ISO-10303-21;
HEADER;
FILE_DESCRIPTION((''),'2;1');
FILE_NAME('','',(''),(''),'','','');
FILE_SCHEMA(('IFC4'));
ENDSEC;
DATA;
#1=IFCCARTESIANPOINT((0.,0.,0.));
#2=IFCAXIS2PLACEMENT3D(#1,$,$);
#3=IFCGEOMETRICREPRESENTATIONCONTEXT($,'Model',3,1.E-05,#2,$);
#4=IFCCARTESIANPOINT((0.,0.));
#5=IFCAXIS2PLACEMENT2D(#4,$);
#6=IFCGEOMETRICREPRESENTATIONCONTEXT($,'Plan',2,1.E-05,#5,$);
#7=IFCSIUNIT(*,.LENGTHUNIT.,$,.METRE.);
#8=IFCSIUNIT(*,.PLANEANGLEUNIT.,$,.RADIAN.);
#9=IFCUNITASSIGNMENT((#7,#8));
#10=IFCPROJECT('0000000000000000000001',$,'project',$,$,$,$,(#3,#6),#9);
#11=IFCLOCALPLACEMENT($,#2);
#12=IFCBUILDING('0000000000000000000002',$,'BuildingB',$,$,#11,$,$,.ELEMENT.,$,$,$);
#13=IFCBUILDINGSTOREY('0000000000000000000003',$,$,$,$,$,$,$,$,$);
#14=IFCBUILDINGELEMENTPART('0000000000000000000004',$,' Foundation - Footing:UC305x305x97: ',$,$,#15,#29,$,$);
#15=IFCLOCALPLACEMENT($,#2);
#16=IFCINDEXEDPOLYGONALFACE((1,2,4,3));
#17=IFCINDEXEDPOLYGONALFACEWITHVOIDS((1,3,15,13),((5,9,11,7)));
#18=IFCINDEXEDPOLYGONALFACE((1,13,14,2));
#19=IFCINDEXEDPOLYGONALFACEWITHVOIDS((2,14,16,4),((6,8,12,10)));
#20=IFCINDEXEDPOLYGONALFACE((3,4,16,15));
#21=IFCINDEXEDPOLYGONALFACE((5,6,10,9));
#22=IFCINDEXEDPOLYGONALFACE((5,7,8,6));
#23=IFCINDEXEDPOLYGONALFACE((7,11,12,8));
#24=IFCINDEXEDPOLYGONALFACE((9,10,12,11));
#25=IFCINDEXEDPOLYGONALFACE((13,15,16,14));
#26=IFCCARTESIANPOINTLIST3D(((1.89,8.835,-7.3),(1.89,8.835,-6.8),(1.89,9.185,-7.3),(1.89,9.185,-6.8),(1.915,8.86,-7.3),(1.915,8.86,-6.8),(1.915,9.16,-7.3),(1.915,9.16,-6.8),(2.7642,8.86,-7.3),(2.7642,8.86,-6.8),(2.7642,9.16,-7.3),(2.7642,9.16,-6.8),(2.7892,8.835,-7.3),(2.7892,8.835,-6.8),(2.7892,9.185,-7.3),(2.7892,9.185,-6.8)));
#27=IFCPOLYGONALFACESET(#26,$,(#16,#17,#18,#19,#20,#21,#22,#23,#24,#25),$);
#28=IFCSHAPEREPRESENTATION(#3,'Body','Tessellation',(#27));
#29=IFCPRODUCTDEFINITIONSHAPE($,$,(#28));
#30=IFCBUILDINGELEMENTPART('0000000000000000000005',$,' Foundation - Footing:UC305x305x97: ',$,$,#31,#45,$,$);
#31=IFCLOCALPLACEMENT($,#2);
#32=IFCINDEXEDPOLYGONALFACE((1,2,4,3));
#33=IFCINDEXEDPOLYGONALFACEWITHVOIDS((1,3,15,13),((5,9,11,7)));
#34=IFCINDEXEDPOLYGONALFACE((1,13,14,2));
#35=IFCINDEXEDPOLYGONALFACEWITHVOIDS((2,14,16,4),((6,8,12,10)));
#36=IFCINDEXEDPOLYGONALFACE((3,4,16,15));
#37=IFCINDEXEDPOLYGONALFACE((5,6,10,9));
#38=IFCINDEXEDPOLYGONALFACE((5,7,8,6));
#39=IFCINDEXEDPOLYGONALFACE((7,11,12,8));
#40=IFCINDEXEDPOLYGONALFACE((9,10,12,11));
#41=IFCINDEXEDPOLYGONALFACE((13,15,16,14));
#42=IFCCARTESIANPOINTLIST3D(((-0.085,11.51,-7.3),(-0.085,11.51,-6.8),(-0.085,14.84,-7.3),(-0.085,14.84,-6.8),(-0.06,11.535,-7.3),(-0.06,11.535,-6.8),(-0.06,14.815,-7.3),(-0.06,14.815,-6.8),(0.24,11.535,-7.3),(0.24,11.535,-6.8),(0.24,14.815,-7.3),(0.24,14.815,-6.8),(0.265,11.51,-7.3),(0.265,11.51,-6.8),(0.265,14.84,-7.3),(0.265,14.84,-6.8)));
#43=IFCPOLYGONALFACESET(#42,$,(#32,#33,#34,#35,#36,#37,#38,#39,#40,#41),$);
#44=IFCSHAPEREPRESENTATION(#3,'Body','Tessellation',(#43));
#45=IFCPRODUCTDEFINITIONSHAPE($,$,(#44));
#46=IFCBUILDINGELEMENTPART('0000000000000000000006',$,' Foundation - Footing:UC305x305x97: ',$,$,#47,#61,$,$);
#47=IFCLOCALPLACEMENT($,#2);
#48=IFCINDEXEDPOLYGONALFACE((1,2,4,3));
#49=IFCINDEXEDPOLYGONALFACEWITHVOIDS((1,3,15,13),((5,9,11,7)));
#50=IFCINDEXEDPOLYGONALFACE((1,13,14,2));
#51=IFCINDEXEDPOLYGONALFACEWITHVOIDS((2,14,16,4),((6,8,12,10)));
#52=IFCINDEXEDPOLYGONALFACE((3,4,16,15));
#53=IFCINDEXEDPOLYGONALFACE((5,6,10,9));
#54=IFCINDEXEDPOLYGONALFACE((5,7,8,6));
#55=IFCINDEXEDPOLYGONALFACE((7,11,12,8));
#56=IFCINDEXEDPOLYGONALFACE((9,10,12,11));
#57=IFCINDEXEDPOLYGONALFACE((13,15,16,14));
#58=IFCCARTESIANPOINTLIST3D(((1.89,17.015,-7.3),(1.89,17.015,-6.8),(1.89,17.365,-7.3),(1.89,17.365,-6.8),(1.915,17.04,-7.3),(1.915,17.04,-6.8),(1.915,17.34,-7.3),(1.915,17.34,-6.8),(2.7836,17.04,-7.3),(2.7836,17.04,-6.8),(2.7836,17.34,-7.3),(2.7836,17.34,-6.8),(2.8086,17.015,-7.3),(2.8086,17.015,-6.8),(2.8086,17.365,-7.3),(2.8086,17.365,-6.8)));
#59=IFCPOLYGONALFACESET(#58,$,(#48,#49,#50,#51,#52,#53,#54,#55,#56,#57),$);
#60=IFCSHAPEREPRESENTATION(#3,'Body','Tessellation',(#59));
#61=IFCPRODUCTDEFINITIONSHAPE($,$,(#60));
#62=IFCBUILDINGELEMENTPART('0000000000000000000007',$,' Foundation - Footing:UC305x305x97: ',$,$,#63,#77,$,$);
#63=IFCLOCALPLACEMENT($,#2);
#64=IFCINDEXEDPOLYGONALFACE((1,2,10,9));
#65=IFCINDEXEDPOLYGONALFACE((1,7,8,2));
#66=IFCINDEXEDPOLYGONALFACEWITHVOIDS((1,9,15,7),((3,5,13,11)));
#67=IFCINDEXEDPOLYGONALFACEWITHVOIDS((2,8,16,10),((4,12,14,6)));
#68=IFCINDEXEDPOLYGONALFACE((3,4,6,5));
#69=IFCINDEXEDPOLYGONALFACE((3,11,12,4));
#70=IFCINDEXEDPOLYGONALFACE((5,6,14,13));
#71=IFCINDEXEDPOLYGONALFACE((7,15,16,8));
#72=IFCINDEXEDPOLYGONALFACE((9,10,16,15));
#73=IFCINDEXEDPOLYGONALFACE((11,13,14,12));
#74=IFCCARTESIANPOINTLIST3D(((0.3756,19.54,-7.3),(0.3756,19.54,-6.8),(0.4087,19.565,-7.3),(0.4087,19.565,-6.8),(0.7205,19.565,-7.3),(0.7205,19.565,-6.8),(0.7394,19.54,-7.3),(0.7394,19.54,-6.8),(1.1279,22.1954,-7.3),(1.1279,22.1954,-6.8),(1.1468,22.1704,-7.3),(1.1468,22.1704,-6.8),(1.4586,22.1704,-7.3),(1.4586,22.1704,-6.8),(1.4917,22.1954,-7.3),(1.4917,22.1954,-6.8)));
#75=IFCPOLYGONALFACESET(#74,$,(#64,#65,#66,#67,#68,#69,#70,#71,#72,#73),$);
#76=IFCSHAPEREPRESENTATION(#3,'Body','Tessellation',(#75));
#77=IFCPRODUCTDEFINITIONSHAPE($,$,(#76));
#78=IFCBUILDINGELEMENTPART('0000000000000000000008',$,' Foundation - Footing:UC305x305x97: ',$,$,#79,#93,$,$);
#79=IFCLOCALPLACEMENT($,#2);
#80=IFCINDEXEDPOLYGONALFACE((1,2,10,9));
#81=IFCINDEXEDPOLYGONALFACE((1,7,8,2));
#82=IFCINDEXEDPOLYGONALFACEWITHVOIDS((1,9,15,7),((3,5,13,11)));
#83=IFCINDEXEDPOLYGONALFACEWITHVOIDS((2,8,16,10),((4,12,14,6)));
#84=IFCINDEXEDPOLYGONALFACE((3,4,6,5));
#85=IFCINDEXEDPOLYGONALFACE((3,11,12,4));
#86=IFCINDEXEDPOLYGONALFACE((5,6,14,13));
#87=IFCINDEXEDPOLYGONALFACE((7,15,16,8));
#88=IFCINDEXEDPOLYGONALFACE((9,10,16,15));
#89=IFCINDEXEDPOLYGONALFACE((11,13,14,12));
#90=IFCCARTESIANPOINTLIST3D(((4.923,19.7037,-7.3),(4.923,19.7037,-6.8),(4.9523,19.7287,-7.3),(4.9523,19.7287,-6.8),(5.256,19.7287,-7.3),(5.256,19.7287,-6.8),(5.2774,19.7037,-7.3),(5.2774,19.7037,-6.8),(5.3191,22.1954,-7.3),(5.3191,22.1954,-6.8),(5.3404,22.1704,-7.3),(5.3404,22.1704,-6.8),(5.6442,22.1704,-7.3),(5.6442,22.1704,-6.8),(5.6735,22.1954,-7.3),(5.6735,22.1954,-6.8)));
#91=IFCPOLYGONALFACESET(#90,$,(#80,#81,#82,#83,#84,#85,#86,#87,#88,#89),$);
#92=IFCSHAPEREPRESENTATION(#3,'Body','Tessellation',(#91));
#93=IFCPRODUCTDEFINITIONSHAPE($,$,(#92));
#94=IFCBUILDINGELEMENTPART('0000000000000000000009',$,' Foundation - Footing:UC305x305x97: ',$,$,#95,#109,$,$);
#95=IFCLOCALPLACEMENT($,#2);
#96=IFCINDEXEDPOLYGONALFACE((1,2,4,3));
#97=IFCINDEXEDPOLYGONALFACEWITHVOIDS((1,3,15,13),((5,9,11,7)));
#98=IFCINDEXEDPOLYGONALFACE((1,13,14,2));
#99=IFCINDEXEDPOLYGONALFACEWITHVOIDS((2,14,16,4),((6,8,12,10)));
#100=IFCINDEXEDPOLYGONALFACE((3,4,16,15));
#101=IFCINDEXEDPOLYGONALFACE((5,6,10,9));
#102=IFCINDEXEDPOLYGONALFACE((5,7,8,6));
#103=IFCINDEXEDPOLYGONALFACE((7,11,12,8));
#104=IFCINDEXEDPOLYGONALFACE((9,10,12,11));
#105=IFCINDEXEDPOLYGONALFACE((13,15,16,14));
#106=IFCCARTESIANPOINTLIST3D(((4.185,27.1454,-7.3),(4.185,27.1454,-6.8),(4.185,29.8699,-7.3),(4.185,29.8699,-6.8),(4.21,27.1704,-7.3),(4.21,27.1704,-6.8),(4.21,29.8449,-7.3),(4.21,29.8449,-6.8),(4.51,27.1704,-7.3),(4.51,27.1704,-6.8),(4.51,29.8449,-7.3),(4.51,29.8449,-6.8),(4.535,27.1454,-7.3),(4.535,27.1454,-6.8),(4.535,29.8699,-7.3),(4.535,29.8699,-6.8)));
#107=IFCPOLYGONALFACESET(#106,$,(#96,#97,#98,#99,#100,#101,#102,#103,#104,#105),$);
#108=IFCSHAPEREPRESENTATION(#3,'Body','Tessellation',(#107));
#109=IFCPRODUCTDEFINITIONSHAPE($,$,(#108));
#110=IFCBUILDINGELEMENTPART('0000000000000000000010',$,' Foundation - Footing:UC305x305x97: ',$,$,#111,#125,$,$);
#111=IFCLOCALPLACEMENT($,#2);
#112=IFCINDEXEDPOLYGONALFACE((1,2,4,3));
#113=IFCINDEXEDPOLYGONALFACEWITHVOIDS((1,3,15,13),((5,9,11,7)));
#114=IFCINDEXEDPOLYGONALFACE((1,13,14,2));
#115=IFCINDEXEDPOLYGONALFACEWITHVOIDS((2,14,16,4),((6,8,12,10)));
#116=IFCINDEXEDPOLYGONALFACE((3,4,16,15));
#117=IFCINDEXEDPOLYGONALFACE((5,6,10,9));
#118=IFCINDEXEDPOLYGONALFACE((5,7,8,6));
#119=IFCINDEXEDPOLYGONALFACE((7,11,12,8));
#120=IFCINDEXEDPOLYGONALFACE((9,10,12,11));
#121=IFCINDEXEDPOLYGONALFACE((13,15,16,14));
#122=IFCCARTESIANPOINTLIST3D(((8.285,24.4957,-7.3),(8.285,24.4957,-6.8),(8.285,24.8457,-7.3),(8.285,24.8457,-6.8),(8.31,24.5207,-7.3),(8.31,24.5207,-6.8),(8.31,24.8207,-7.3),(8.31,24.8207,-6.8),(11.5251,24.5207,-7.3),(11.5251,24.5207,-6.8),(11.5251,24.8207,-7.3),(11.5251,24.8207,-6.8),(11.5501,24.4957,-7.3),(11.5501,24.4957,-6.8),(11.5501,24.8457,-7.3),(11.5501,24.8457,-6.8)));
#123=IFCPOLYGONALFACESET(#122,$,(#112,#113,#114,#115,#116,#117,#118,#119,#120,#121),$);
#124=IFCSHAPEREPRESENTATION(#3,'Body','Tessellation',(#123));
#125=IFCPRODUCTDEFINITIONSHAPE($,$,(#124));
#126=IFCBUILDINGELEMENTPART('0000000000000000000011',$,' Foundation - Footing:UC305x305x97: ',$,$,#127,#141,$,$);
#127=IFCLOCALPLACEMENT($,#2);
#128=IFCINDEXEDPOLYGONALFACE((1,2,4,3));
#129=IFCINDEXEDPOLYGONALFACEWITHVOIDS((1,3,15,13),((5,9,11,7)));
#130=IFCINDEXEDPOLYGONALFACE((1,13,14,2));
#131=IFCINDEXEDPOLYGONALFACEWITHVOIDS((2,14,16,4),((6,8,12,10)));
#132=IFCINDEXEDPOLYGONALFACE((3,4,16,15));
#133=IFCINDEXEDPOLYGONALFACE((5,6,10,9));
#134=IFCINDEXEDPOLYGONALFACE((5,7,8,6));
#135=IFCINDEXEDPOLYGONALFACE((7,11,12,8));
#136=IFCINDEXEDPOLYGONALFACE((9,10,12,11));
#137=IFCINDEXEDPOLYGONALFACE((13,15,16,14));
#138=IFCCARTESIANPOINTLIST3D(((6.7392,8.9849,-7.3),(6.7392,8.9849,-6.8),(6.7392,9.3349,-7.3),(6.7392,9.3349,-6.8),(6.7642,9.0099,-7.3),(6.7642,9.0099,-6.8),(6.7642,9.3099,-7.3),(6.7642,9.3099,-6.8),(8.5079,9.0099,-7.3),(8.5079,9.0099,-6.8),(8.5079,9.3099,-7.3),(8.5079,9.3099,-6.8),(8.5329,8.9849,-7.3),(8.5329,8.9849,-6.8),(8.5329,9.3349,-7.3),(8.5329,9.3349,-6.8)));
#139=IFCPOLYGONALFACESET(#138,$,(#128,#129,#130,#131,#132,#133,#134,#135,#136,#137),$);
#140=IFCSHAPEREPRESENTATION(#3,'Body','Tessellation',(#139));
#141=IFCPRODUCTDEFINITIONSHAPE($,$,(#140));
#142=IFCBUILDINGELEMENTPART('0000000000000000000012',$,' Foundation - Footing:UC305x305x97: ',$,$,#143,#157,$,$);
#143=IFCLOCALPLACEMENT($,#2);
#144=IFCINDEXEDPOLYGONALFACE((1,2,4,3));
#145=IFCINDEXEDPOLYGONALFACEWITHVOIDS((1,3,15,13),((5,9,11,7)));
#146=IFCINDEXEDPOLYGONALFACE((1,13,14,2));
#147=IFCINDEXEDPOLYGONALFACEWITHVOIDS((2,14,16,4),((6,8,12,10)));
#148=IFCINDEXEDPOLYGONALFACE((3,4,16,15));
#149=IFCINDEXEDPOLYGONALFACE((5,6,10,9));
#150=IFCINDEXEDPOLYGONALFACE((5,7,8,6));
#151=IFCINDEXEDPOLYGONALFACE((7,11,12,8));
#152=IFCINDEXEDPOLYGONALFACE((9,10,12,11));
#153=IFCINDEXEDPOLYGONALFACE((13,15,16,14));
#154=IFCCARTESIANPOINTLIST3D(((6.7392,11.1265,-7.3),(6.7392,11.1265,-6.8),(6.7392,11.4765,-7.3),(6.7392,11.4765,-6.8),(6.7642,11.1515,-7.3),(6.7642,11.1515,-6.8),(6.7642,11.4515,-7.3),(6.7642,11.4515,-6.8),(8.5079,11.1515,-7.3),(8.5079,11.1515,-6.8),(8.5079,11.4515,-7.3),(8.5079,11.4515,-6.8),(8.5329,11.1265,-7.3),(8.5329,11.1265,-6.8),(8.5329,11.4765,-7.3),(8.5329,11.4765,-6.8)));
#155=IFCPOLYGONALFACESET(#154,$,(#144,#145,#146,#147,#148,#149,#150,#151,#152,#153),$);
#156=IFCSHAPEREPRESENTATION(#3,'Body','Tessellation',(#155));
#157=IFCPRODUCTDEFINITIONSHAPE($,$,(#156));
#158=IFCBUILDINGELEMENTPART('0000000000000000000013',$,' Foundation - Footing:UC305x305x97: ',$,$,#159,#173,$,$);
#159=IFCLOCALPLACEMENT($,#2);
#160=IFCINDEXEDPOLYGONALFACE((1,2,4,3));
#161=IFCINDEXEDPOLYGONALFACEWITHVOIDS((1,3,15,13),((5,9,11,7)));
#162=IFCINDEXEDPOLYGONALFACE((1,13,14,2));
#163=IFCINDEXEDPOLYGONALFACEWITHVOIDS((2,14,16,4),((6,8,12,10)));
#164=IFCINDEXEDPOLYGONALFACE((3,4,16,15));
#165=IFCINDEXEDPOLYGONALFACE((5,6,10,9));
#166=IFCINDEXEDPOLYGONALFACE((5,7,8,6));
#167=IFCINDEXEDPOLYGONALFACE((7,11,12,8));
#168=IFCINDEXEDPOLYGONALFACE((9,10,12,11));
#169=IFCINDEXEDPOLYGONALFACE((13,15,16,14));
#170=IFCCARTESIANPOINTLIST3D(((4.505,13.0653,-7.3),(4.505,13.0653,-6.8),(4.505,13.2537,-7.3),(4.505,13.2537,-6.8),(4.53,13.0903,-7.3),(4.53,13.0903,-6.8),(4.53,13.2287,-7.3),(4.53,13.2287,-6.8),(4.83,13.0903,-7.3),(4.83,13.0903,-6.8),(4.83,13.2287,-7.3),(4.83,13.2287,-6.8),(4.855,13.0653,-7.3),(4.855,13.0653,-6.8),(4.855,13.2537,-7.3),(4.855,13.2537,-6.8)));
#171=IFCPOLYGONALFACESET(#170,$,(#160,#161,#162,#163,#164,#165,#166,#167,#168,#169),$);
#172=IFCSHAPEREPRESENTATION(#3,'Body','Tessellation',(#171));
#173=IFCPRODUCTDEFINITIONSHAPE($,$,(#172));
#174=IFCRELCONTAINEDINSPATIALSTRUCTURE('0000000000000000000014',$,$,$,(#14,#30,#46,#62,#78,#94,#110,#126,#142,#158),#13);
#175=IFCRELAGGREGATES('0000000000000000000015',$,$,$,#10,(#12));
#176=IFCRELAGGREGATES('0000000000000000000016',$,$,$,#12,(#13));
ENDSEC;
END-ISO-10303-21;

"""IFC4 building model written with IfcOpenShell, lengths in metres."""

from ifc_helpers import new_model, si_unit, origin, origin_2d, place, context, project, spatial, polyline, outline, extrude, element, save


model = new_model("IFC4")

# Units and contexts
model_context = context("Model", 3, precision=1e-05, world=origin())
plan_context = context("Plan", 2, precision=1e-05, world=origin_2d())
ifc_project = project(units=[si_unit("LENGTHUNIT", "METRE"), si_unit("PLANEANGLEUNIT", "RADIAN")], contexts=[model_context, plan_context])

# Building, storey
building_placement = place(None, origin())
building = spatial("IfcBuilding", under=ifc_project, at=building_placement, Name="BuildingB", CompositionType="ELEMENT")
storey = spatial("IfcBuildingStorey", under=building)

# Building element parts, openings
building_element_part_1 = element("IfcBuildingElementPart", 1, inside=storey, Name=" Foundation - Footing:UC305x305x97: ", context=model_context, shape_type="SweptSolid", body=[
    extrude(outline(polyline([(1.89, 8.835, -7.3), (1.89, 9.185, -7.3), (2.7892, 9.185, -7.3), (2.7892, 8.835, -7.3), (1.89, 8.835, -7.3)])), None, (0.0, 0.0, 1.0), 0.5),
])
element("IfcOpeningElement", 2, inside=storey, cuts=building_element_part_1, context=model_context, shape_type="SweptSolid", body=[
    extrude(outline(polyline([(1.915, 8.86, -7.3), (1.915, 9.16, -7.3), (2.7642, 9.16, -7.3), (2.7642, 8.86, -7.3), (1.915, 8.86, -7.3)])), None, (0.0, 0.0, 1.0), 0.5),
])
building_element_part_2 = element("IfcBuildingElementPart", 3, inside=storey, Name=" Foundation - Footing:UC305x305x97: ", context=model_context, shape_type="SweptSolid", body=[
    extrude(outline(polyline([(-0.085, 11.51, -7.3), (-0.085, 14.84, -7.3), (0.265, 14.84, -7.3), (0.265, 11.51, -7.3), (-0.085, 11.51, -7.3)])), None, (0.0, 0.0, 1.0), 0.5),
])
element("IfcOpeningElement", 4, inside=storey, cuts=building_element_part_2, context=model_context, shape_type="SweptSolid", body=[
    extrude(outline(polyline([(-0.06, 11.535, -7.3), (-0.06, 14.815, -7.3), (0.24, 14.815, -7.3), (0.24, 11.535, -7.3), (-0.06, 11.535, -7.3)])), None, (0.0, 0.0, 1.0), 0.5),
])
building_element_part_3 = element("IfcBuildingElementPart", 5, inside=storey, Name=" Foundation - Footing:UC305x305x97: ", context=model_context, shape_type="SweptSolid", body=[
    extrude(outline(polyline([(1.89, 17.015, -7.3), (1.89, 17.365, -7.3), (2.8086, 17.365, -7.3), (2.8086, 17.015, -7.3), (1.89, 17.015, -7.3)])), None, (0.0, 0.0, 1.0), 0.5),
])
element("IfcOpeningElement", 6, inside=storey, cuts=building_element_part_3, context=model_context, shape_type="SweptSolid", body=[
    extrude(outline(polyline([(1.915, 17.04, -7.3), (1.915, 17.34, -7.3), (2.7836, 17.34, -7.3), (2.7836, 17.04, -7.3), (1.915, 17.04, -7.3)])), None, (0.0, 0.0, 1.0), 0.5),
])
building_element_part_4 = element("IfcBuildingElementPart", 7, inside=storey, Name=" Foundation - Footing:UC305x305x97: ", context=model_context, shape_type="SweptSolid", body=[
    extrude(outline(polyline([(0.3756, 19.54, -7.3), (1.1279, 22.1954, -7.3), (1.4917, 22.1954, -7.3), (0.7394, 19.54, -7.3), (0.3756, 19.54, -7.3)])), None, (0.0, 0.0, 1.0), 0.5),
])
element("IfcOpeningElement", 8, inside=storey, cuts=building_element_part_4, context=model_context, shape_type="SweptSolid", body=[
    extrude(outline(polyline([(0.4087, 19.565, -7.3), (1.1468, 22.1704, -7.3), (1.4586, 22.1704, -7.3), (0.7205, 19.565, -7.3), (0.4087, 19.565, -7.3)])), None, (0.0, 0.0, 1.0), 0.5),
])
building_element_part_5 = element("IfcBuildingElementPart", 9, inside=storey, Name=" Foundation - Footing:UC305x305x97: ", context=model_context, shape_type="SweptSolid", body=[
    extrude(outline(polyline([(5.2774, 19.7037, -7.3), (4.923, 19.7037, -7.3), (5.3191, 22.1954, -7.3), (5.6735, 22.1954, -7.3), (5.2774, 19.7037, -7.3)])), None, (0.0, 0.0, 1.0), 0.5),
])
element("IfcOpeningElement", 10, inside=storey, cuts=building_element_part_5, context=model_context, shape_type="SweptSolid", body=[
    extrude(outline(polyline([(5.256, 19.7287, -7.3), (4.9523, 19.7287, -7.3), (5.3404, 22.1704, -7.3), (5.6442, 22.1704, -7.3), (5.256, 19.7287, -7.3)])), None, (0.0, 0.0, 1.0), 0.5),
])
building_element_part_6 = element("IfcBuildingElementPart", 11, inside=storey, Name=" Foundation - Footing:UC305x305x97: ", context=model_context, shape_type="SweptSolid", body=[
    extrude(outline(polyline([(4.535, 27.1454, -7.3), (4.185, 27.1454, -7.3), (4.185, 29.8699, -7.3), (4.535, 29.8699, -7.3), (4.535, 27.1454, -7.3)])), None, (0.0, 0.0, 1.0), 0.5),
])
element("IfcOpeningElement", 12, inside=storey, cuts=building_element_part_6, context=model_context, shape_type="SweptSolid", body=[
    extrude(outline(polyline([(4.51, 27.1704, -7.3), (4.21, 27.1704, -7.3), (4.21, 29.8449, -7.3), (4.51, 29.8449, -7.3), (4.51, 27.1704, -7.3)])), None, (0.0, 0.0, 1.0), 0.5),
])
building_element_part_7 = element("IfcBuildingElementPart", 13, inside=storey, Name=" Foundation - Footing:UC305x305x97: ", context=model_context, shape_type="SweptSolid", body=[
    extrude(outline(polyline([(8.285, 24.4957, -7.3), (8.285, 24.8457, -7.3), (11.5501, 24.8457, -7.3), (11.5501, 24.4957, -7.3), (8.285, 24.4957, -7.3)])), None, (0.0, 0.0, 1.0), 0.5),
])
element("IfcOpeningElement", 14, inside=storey, cuts=building_element_part_7, context=model_context, shape_type="SweptSolid", body=[
    extrude(outline(polyline([(8.31, 24.5207, -7.3), (8.31, 24.8207, -7.3), (11.5251, 24.8207, -7.3), (11.5251, 24.5207, -7.3), (8.31, 24.5207, -7.3)])), None, (0.0, 0.0, 1.0), 0.5),
])
building_element_part_8 = element("IfcBuildingElementPart", 15, inside=storey, Name=" Foundation - Footing:UC305x305x97: ", context=model_context, shape_type="SweptSolid", body=[
    extrude(outline(polyline([(6.7392, 8.9849, -7.3), (6.7392, 9.3349, -7.3), (8.5329, 9.3349, -7.3), (8.5329, 8.9849, -7.3), (6.7392, 8.9849, -7.3)])), None, (0.0, 0.0, 1.0), 0.5),
])
element("IfcOpeningElement", 16, inside=storey, cuts=building_element_part_8, context=model_context, shape_type="SweptSolid", body=[
    extrude(outline(polyline([(6.7642, 9.0099, -7.3), (6.7642, 9.3099, -7.3), (8.5079, 9.3099, -7.3), (8.5079, 9.0099, -7.3), (6.7642, 9.0099, -7.3)])), None, (0.0, 0.0, 1.0), 0.5),
])
building_element_part_9 = element("IfcBuildingElementPart", 17, inside=storey, Name=" Foundation - Footing:UC305x305x97: ", context=model_context, shape_type="SweptSolid", body=[
    extrude(outline(polyline([(6.7392, 11.1265, -7.3), (6.7392, 11.4765, -7.3), (8.5329, 11.4765, -7.3), (8.5329, 11.1265, -7.3), (6.7392, 11.1265, -7.3)])), None, (0.0, 0.0, 1.0), 0.5),
])
element("IfcOpeningElement", 18, inside=storey, cuts=building_element_part_9, context=model_context, shape_type="SweptSolid", body=[
    extrude(outline(polyline([(6.7642, 11.1515, -7.3), (6.7642, 11.4515, -7.3), (8.5079, 11.4515, -7.3), (8.5079, 11.1515, -7.3), (6.7642, 11.1515, -7.3)])), None, (0.0, 0.0, 1.0), 0.5),
])
building_element_part_10 = element("IfcBuildingElementPart", 19, inside=storey, Name=" Foundation - Footing:UC305x305x97: ", context=model_context, shape_type="SweptSolid", body=[
    extrude(outline(polyline([(4.505, 13.0653, -7.3), (4.505, 13.2537, -7.3), (4.855, 13.2537, -7.3), (4.855, 13.0653, -7.3), (4.505, 13.0653, -7.3)])), None, (0.0, 0.0, 1.0), 0.5),
])
element("IfcOpeningElement", 20, inside=storey, cuts=building_element_part_10, context=model_context, shape_type="SweptSolid", body=[
    extrude(outline(polyline([(4.53, 13.0903, -7.3), (4.53, 13.2287, -7.3), (4.83, 13.2287, -7.3), (4.83, 13.0903, -7.3), (4.53, 13.0903, -7.3)])), None, (0.0, 0.0, 1.0), 0.5),
])

save(model, "model.ifc")
